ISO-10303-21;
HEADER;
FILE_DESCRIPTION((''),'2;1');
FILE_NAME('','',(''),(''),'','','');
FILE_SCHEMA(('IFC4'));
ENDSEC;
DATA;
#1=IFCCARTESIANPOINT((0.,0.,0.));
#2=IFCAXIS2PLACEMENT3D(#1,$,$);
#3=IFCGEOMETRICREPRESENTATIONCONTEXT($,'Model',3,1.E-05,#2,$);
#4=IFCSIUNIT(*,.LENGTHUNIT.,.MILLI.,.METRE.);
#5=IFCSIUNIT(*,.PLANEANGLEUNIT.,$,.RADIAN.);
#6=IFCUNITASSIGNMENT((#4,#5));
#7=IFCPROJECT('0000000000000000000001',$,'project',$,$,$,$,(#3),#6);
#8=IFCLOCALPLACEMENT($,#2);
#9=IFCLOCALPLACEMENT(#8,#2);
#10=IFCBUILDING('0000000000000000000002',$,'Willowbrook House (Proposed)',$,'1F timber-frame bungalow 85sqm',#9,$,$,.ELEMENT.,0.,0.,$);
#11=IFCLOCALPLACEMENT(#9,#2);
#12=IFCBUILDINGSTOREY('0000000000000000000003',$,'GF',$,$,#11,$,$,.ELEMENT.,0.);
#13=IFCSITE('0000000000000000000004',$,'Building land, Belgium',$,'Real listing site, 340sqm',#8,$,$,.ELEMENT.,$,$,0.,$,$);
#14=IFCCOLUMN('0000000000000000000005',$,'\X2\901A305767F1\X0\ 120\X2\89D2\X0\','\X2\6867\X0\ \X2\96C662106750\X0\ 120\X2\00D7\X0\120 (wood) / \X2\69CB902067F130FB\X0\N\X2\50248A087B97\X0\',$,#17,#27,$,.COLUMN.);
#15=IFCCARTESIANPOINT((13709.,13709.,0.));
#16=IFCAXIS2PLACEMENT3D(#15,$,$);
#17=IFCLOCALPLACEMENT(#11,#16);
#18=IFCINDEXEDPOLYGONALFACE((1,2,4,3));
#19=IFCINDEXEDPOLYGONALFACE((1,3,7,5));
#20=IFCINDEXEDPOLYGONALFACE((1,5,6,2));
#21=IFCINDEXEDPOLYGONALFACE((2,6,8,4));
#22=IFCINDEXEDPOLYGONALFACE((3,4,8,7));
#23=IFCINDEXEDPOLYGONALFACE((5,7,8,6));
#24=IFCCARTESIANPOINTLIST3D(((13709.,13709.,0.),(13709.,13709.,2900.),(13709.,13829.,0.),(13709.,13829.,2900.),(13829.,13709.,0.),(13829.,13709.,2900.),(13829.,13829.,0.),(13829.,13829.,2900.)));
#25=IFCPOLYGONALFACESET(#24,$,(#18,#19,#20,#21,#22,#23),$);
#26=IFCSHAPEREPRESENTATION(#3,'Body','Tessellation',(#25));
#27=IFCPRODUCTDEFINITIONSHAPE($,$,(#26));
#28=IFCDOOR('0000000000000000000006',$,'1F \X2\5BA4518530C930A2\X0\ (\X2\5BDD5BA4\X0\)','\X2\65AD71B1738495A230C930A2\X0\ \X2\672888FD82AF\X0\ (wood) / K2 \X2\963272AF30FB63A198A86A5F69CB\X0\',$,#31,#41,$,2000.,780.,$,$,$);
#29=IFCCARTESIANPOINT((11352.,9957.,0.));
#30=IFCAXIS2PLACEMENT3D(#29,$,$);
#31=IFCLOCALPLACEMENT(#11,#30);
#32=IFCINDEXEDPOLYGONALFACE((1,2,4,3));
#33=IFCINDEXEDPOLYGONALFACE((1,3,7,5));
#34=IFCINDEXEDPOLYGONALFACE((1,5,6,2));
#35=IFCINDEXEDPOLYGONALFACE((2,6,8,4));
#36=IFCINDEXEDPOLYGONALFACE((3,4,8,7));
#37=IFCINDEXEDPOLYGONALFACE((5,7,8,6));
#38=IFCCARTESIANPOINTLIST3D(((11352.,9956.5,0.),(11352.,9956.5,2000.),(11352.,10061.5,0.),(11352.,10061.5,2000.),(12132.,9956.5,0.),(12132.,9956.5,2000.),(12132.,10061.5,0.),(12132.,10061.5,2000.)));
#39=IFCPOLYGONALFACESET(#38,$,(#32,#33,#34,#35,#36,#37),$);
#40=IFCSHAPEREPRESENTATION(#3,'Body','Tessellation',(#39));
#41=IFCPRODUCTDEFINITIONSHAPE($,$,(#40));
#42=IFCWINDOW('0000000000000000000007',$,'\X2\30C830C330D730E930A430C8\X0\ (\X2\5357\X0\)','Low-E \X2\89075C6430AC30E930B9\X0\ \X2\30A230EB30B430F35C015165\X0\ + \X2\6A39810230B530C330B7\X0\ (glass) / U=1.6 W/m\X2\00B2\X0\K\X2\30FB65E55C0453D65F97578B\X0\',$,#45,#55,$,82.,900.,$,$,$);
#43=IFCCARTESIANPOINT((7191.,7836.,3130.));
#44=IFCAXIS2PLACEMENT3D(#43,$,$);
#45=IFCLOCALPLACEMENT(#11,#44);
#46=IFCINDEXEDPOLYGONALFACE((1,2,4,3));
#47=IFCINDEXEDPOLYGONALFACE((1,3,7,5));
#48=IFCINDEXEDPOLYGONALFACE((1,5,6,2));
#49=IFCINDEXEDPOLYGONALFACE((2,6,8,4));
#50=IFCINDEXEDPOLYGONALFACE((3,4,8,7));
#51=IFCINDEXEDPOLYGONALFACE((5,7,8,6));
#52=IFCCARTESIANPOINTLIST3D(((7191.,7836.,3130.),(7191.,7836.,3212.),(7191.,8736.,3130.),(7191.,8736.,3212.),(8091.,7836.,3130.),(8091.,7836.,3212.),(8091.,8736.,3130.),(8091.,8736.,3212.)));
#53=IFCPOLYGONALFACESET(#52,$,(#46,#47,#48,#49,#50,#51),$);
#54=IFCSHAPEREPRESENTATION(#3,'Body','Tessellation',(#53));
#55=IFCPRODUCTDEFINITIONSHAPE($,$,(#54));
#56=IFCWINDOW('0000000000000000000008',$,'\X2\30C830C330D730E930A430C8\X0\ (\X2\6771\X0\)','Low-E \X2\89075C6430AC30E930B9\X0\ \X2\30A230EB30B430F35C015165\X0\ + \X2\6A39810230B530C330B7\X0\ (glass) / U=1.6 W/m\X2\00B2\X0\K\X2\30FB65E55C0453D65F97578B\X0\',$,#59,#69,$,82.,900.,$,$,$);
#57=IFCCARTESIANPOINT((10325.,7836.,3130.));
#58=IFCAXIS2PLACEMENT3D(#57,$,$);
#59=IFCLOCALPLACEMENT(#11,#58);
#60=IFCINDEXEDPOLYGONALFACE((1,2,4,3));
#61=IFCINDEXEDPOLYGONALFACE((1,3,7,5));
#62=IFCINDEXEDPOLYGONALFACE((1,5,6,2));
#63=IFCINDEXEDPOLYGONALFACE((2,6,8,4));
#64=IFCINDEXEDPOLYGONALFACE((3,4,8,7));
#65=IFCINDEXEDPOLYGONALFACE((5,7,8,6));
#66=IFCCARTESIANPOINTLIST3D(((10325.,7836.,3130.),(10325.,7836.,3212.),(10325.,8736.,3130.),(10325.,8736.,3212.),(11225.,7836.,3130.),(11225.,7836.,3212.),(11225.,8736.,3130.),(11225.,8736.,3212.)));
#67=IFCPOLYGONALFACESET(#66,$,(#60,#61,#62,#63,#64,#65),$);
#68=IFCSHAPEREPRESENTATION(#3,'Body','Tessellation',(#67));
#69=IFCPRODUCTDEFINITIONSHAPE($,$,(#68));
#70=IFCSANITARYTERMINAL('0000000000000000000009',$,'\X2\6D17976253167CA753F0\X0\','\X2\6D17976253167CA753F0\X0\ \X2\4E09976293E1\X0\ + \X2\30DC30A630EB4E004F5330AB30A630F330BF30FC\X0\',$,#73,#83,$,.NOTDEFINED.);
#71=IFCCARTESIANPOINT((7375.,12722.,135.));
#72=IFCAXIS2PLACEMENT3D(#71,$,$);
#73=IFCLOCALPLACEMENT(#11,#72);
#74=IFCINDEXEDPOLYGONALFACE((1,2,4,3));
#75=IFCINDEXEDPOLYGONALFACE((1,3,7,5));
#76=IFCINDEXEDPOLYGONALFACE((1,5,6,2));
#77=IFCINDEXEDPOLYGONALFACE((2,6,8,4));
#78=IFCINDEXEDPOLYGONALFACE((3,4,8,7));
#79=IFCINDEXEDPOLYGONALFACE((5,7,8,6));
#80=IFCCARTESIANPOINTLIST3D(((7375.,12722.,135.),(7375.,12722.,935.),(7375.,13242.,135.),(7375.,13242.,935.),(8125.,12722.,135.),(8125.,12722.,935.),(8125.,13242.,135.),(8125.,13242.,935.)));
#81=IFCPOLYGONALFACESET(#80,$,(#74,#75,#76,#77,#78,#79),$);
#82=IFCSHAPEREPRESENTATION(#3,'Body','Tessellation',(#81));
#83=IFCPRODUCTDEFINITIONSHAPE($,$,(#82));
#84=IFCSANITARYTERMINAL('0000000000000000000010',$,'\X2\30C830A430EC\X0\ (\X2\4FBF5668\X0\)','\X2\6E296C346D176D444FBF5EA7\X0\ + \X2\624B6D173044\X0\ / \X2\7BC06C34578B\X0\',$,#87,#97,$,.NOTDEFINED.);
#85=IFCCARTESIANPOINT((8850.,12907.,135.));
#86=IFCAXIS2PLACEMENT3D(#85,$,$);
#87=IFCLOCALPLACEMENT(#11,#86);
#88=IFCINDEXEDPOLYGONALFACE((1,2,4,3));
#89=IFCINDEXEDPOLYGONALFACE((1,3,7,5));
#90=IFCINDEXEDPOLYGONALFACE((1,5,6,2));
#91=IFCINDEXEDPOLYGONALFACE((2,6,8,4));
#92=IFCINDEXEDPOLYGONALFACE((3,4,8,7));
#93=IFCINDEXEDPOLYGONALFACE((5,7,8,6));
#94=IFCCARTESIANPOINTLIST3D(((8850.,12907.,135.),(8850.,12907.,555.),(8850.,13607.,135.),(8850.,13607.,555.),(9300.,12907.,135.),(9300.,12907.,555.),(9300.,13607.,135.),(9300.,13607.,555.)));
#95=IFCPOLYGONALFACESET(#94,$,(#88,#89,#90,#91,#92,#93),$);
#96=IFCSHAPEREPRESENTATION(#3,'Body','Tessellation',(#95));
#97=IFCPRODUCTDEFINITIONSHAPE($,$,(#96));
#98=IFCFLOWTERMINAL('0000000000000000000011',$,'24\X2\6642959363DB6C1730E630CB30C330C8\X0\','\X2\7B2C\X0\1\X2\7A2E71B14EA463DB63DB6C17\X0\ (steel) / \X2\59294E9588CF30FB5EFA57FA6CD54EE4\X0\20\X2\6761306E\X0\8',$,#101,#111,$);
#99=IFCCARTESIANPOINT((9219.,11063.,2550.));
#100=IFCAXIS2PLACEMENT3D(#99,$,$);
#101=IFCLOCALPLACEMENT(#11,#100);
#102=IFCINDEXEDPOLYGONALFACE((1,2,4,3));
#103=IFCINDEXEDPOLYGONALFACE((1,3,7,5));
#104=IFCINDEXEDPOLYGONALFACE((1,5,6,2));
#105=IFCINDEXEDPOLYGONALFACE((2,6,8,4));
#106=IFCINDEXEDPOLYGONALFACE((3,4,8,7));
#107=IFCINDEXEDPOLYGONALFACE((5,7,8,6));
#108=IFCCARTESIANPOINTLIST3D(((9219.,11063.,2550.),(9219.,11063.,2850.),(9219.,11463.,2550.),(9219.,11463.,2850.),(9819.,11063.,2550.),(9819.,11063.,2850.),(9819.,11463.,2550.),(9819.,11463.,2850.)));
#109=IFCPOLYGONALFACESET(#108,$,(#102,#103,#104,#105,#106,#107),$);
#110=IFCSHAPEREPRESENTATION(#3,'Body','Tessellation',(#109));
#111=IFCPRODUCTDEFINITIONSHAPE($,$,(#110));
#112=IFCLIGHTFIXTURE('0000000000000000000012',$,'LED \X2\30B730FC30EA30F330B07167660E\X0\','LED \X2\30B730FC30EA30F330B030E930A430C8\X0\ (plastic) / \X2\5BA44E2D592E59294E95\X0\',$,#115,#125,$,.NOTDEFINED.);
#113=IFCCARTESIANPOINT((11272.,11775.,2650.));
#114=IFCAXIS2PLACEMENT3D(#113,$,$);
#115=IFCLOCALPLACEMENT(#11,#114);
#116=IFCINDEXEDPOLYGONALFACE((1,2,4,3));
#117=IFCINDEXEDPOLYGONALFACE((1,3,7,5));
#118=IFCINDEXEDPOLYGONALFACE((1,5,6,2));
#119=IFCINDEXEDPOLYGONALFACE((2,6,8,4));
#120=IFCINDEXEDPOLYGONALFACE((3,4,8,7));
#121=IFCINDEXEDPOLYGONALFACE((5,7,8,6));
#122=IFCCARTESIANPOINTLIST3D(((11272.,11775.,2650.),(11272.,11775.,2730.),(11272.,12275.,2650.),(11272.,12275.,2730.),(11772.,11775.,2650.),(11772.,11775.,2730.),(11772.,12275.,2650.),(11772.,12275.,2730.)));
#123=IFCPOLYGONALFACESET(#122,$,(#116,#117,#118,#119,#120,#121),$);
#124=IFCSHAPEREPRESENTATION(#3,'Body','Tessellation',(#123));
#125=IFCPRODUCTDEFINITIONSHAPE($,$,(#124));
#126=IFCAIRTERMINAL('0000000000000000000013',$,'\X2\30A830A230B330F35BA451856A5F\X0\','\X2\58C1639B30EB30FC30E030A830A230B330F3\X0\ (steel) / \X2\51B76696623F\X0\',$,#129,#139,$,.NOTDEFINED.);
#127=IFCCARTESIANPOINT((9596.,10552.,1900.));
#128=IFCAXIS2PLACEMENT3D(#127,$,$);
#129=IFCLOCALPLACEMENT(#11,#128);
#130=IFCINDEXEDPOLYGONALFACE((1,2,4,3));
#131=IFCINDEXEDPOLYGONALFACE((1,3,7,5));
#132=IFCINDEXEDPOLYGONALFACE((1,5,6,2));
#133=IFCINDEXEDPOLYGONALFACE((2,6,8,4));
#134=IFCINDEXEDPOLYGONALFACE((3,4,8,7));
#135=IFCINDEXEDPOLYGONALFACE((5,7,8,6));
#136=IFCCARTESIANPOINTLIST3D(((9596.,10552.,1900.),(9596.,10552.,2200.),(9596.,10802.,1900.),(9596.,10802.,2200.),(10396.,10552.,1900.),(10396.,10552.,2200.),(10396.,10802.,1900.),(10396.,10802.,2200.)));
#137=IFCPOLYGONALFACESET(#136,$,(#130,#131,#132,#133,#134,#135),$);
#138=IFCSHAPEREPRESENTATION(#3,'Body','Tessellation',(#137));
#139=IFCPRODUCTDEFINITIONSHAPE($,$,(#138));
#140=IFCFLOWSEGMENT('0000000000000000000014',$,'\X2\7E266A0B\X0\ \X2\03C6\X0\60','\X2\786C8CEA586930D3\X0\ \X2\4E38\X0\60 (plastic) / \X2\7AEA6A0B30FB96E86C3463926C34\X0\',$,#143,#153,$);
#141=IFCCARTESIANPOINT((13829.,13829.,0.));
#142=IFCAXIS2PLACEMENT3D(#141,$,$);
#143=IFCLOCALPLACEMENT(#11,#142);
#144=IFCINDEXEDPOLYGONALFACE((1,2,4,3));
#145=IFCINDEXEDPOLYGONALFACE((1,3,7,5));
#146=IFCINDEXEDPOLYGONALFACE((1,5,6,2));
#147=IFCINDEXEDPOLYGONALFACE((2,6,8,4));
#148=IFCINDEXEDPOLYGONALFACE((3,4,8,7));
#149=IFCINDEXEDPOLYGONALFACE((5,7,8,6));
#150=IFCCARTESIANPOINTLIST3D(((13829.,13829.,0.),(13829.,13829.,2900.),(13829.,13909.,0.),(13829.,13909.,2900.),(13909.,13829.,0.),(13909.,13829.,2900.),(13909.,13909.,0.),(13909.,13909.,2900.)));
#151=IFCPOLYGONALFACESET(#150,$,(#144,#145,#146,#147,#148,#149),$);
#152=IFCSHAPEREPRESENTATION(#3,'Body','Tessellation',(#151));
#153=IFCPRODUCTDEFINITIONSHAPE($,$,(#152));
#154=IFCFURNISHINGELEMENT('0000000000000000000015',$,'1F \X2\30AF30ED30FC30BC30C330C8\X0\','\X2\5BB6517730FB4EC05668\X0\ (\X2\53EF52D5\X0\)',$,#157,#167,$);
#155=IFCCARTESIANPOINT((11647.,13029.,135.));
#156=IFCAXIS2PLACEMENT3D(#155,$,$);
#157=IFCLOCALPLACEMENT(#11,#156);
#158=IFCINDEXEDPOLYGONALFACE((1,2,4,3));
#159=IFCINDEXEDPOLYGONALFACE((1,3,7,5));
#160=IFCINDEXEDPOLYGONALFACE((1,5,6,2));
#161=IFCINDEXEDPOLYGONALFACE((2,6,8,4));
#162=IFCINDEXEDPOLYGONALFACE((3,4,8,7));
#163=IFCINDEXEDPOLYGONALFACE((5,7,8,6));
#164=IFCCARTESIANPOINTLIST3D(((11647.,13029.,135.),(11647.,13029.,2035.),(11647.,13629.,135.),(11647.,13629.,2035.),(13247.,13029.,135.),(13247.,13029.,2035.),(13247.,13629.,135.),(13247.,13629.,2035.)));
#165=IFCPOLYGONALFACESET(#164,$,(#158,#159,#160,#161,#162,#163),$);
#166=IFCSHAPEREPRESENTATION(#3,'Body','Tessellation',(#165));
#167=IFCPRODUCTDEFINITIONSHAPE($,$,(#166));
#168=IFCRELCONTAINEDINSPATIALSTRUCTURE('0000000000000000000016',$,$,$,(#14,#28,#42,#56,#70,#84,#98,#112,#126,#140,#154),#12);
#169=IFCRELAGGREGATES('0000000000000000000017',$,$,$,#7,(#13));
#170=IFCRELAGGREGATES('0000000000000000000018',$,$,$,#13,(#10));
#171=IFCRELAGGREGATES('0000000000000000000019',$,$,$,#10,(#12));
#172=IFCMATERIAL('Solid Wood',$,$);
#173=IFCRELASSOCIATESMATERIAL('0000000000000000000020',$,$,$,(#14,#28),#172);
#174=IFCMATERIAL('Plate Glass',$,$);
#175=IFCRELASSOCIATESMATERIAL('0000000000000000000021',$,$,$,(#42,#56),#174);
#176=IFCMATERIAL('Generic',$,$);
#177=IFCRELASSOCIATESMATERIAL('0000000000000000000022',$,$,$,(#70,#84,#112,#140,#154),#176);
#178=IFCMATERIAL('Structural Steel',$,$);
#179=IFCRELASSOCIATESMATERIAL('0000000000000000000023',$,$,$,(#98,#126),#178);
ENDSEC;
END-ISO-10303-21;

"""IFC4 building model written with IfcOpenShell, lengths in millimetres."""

from ifc_helpers import new_model, si_unit, frame, frame_2d, origin, place, context, project, spatial, rectangle, extrude, material, element, save


model = new_model("IFC4")

# Units and contexts
model_context = context("Model", 3, precision=1e-05, world=origin())
ifc_project = project(units=[si_unit("LENGTHUNIT", "METRE", prefix="MILLI"), si_unit("PLANEANGLEUNIT", "RADIAN")], contexts=[model_context])

# Site, building, storey
site_placement = place(None, origin())
site = spatial("IfcSite", under=ifc_project, at=site_placement, Name="Building land, Belgium", ObjectType="Real listing site, 340sqm", CompositionType="ELEMENT", RefElevation=0.0)
building_placement = place(site_placement, origin())
building = spatial("IfcBuilding", under=site, at=building_placement, Name="Willowbrook House (Proposed)", ObjectType="1F timber-frame bungalow 85sqm", CompositionType="ELEMENT", ElevationOfRefHeight=0.0, ElevationOfTerrain=0.0)
storey_placement = place(building_placement, origin())
storey = spatial("IfcBuildingStorey", under=building, at=storey_placement, Name="GF", CompositionType="ELEMENT", Elevation=0.0)

# Column
ifc_material_1 = material(Name="Solid Wood")
column_1_placement = place(storey_placement, frame((13709.0, 13709.0, 0.0)))
element("IfcColumn", 1, at=column_1_placement, inside=storey, material=ifc_material_1, Name="通し柱 120角", Description="桧 集成材 120×120 (wood) / 構造柱・N値計算", PredefinedType="COLUMN", context=model_context, shape_type="SweptSolid", body=[
    extrude(rectangle(XDim=120.0, YDim=120.0, at=frame_2d((60.0, 60.0))), frame((13709.0, 13709.0, 0.0)), (0.0, 0.0, 1.0), 2900.0),
])

# Door
door_placement = place(storey_placement, frame((11352.0, 9957.0, 0.0)))
element("IfcDoor", 2, at=door_placement, inside=storey, material=ifc_material_1, Name="1F 室内ドア (寝室)", Description="断熱玄関ドア 木製芯 (wood) / K2 防犯・採風機構", OverallHeight=2000.0, OverallWidth=780.0, context=model_context, shape_type="SweptSolid", body=[
    extrude(rectangle(XDim=780.0, YDim=105.0, at=frame_2d((390.0, 52.0))), frame((11352.0, 9957.0, 0.0)), (0.0, 0.0, 1.0), 2000.0),
])

# Windows
ifc_material_2 = material(Name="Plate Glass")
window_1_placement = place(storey_placement, frame((7191.0, 7836.0, 3130.0)))
element("IfcWindow", 3, at=window_1_placement, inside=storey, material=ifc_material_2, Name="トップライト (南)", Description="Low-E 複層ガラス アルゴン封入 + 樹脂サッシ (glass) / U=1.6 W/m²K・日射取得型", OverallHeight=82.0, OverallWidth=900.0, context=model_context, shape_type="SweptSolid", body=[
    extrude(rectangle(XDim=900.0, YDim=900.0, at=frame_2d((450.0, 450.0))), frame((7191.0, 7836.0, 3130.0)), (0.0, 0.0, 1.0), 82.0),
])
window_2_placement = place(storey_placement, frame((10325.0, 7836.0, 3130.0)))
element("IfcWindow", 4, at=window_2_placement, inside=storey, material=ifc_material_2, Name="トップライト (東)", Description="Low-E 複層ガラス アルゴン封入 + 樹脂サッシ (glass) / U=1.6 W/m²K・日射取得型", OverallHeight=82.0, OverallWidth=900.0, context=model_context, shape_type="SweptSolid", body=[
    extrude(rectangle(XDim=900.0, YDim=900.0, at=frame_2d((450.0, 450.0))), frame((10325.0, 7836.0, 3130.0)), (0.0, 0.0, 1.0), 82.0),
])

# Sanitary terminals
ifc_material_3 = material(Name="Generic")
sanitary_terminal_1_placement = place(storey_placement, frame((7375.0, 12722.0, 135.0)))
element("IfcSanitaryTerminal", 5, at=sanitary_terminal_1_placement, inside=storey, material=ifc_material_3, Name="洗面化粧台", Description="洗面化粧台 三面鏡 + ボウル一体カウンター", PredefinedType="NOTDEFINED", context=model_context, shape_type="SweptSolid", body=[
    extrude(rectangle(XDim=750.0, YDim=520.0, at=frame_2d((375.0, 260.0))), frame((7375.0, 12722.0, 135.0)), (0.0, 0.0, 1.0), 800.0),
])
sanitary_terminal_2_placement = place(storey_placement, frame((8850.0, 12907.0, 135.0)))
element("IfcSanitaryTerminal", 6, at=sanitary_terminal_2_placement, inside=storey, material=ifc_material_3, Name="トイレ (便器)", Description="温水洗浄便座 + 手洗い / 節水型", PredefinedType="NOTDEFINED", context=model_context, shape_type="SweptSolid", body=[
    extrude(rectangle(XDim=450.0, YDim=700.0, at=frame_2d((225.0, 350.0))), frame((8850.0, 12907.0, 135.0)), (0.0, 0.0, 1.0), 420.0),
])

# Flow terminal
ifc_material_4 = material(Name="Structural Steel")
flow_terminal_placement = place(storey_placement, frame((9219.0, 11063.0, 2550.0)))
element("IfcFlowTerminal", 7, at=flow_terminal_placement, inside=storey, material=ifc_material_4, Name="24時間換気ユニット", Description="第1種熱交換換気 (steel) / 天井裏・建基法令20条の8", context=model_context, shape_type="SweptSolid", body=[
    extrude(rectangle(XDim=600.0, YDim=400.0, at=frame_2d((300.0, 200.0))), frame((9219.0, 11063.0, 2550.0)), (0.0, 0.0, 1.0), 300.0),
])

# Light fixture
light_fixture_placement = place(storey_placement, frame((11272.0, 11775.0, 2650.0)))
element("IfcLightFixture", 8, at=light_fixture_placement, inside=storey, material=ifc_material_3, Name="LED シーリング照明", Description="LED シーリングライト (plastic) / 室中央天井", PredefinedType="NOTDEFINED", context=model_context, shape_type="SweptSolid", body=[
    extrude(rectangle(XDim=500.0, YDim=500.0, at=frame_2d((250.0, 250.0))), frame((11272.0, 11775.0, 2650.0)), (0.0, 0.0, 1.0), 80.0),
])

# Air terminal
air_terminal_placement = place(storey_placement, frame((9596.0, 10552.0, 1900.0)))
element("IfcAirTerminal", 9, at=air_terminal_placement, inside=storey, material=ifc_material_4, Name="エアコン室内機", Description="壁掛ルームエアコン (steel) / 冷暖房", PredefinedType="NOTDEFINED", context=model_context, shape_type="SweptSolid", body=[
    extrude(rectangle(XDim=800.0, YDim=250.0, at=frame_2d((400.0, 125.0))), frame((9596.0, 10552.0, 1900.0)), (0.0, 0.0, 1.0), 300.0),
])

# Flow segment
flow_segment_placement = place(storey_placement, frame((13829.0, 13829.0, 0.0)))
element("IfcFlowSegment", 10, at=flow_segment_placement, inside=storey, material=ifc_material_3, Name="縦樋 φ60", Description="硬質塩ビ 丸60 (plastic) / 竪樋・雨水排水", context=model_context, shape_type="SweptSolid", body=[
    extrude(rectangle(XDim=80.0, YDim=80.0, at=frame_2d((40.0, 40.0))), frame((13829.0, 13829.0, 0.0)), (0.0, 0.0, 1.0), 2900.0),
])

# Furnishing element
furnishing_placement = place(storey_placement, frame((11647.0, 13029.0, 135.0)))
element("IfcFurnishingElement", 11, at=furnishing_placement, inside=storey, material=ifc_material_3, Name="1F クローゼット", Description="家具・什器 (可動)", context=model_context, shape_type="SweptSolid", body=[
    extrude(rectangle(XDim=1600.0, YDim=600.0, at=frame_2d((800.0, 300.0))), frame((11647.0, 13029.0, 135.0)), (0.0, 0.0, 1.0), 1900.0),
])

save(model, "model.ifc")
